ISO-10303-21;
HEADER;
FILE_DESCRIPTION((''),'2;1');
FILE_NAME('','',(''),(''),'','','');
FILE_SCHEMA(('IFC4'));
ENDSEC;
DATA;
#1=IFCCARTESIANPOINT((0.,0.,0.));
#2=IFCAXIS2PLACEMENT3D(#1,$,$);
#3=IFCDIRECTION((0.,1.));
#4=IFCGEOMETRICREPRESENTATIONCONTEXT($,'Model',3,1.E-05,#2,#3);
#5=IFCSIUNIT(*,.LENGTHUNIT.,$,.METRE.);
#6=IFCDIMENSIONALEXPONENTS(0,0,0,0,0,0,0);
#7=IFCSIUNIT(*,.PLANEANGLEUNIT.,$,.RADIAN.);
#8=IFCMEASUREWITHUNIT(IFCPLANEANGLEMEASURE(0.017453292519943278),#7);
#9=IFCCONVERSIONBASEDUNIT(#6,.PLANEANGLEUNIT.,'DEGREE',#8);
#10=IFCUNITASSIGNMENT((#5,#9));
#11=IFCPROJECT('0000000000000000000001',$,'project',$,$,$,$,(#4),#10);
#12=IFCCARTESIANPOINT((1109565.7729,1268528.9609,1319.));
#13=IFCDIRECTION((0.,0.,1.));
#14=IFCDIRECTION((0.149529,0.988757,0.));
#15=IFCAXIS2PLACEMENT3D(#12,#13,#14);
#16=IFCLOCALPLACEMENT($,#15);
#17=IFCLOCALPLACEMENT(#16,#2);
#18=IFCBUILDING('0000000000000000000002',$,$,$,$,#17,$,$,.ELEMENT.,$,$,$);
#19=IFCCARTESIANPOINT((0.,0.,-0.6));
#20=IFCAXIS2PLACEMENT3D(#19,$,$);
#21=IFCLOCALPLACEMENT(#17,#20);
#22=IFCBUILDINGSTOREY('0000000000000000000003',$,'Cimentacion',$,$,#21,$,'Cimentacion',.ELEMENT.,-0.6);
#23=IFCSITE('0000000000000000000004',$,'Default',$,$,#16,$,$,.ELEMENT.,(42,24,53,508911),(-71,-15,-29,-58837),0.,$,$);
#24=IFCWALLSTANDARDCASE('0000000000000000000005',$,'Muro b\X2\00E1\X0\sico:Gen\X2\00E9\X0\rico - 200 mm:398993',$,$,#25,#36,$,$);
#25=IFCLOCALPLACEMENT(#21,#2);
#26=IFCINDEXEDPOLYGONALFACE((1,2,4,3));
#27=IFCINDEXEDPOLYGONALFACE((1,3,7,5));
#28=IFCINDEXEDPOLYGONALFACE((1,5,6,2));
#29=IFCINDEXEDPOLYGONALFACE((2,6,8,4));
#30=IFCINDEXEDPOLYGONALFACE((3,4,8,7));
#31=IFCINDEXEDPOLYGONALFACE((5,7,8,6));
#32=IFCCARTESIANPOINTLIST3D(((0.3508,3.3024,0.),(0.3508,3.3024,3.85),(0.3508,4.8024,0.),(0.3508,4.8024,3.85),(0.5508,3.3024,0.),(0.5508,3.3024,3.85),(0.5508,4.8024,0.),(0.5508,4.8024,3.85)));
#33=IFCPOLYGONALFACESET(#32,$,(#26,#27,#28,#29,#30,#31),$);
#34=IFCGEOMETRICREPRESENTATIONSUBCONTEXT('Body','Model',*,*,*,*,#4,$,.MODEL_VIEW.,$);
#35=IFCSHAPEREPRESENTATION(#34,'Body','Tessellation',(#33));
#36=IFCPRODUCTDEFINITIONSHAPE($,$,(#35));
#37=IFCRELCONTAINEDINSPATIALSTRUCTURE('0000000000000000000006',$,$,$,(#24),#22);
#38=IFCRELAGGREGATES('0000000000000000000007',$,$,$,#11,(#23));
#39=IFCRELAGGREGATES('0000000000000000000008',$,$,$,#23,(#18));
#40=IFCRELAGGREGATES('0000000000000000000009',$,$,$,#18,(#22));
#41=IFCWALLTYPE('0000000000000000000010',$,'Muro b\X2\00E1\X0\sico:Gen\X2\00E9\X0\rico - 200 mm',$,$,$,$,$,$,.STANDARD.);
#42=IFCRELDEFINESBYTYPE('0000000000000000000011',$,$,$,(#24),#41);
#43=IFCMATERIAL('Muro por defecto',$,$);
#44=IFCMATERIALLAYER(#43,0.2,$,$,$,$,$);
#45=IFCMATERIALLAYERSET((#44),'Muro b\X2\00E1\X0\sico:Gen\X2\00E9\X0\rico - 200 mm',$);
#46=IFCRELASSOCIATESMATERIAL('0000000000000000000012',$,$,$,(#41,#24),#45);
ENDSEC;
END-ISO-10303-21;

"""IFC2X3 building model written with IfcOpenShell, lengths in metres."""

from ifc_helpers import new_model, entity, si_unit, converted_unit, direction, frame, frame_2d, origin, place, context, subcontext, project, spatial, rectangle, extrude, material, layer, layer_set, layer_usage, type_object, element, save


model = new_model("IFC2X3")

# Units and contexts
model_context = context("Model", 3, precision=1e-05, world=origin(), true_north=direction((0.0, 1.0)))
body_context = subcontext(model_context, "Body", "Model", "MODEL_VIEW")
ifc_project = project(units=[si_unit("LENGTHUNIT", "METRE"), converted_unit("PLANEANGLEUNIT", "DEGREE", entity("IfcPlaneAngleMeasure", 0.017453292519943278), si_unit("PLANEANGLEUNIT", "RADIAN"), dimensions=[0, 0, 0, 0, 0, 0, 0])], contexts=[model_context])

# Site, building, storey
site_placement = place(None, frame((1109565.7729, 1268528.9609, 1319.0), z_axis=(0.0, 0.0, 1.0), x_axis=(0.149529, 0.988757, 0.0)))
site = spatial("IfcSite", under=ifc_project, at=site_placement, Name="Default", CompositionType="ELEMENT", RefLatitude=(42, 24, 53, 508911), RefLongitude=(-71, -15, -29, -58837), RefElevation=0.0)
building_placement = place(site_placement, origin())
building = spatial("IfcBuilding", under=site, at=building_placement, CompositionType="ELEMENT")
storey_placement = place(building_placement, frame((0.0, 0.0, -0.6)))
storey = spatial("IfcBuildingStorey", under=building, at=storey_placement, Name="Cimentacion", LongName="Cimentacion", CompositionType="ELEMENT", Elevation=-0.6)

# Wall
ifc_material_1 = material(Name="Muro por defecto")
ifc_layer = layer(ifc_material_1, 0.2)
ifc_layer_set = layer_set([ifc_layer], Name="Muro básico:Genérico - 200 mm")
ifc_layer_usage = layer_usage(ifc_layer_set, "AXIS2", "NEGATIVE", 0.1)
wall_type = type_object("IfcWallType", Name="Muro básico:Genérico - 200 mm", PredefinedType="STANDARD", material=ifc_layer_set)
wall_placement = place(storey_placement, frame((0.4508, 4.8024, 0.0), z_axis=(0.0, 0.0, 1.0), x_axis=(0.0, -1.0, 0.0)))
element("IfcWallStandardCase", 1, at=wall_placement, inside=storey, type_object=wall_type, material=ifc_layer_usage, Name="Muro básico:Genérico - 200 mm:398993", context=body_context, shape_type="SweptSolid", body=[
    extrude(rectangle(XDim=1.5, YDim=0.2, at=frame_2d((0.75, 0.0), x_axis=(-1.0, 0.0))), origin(), (0.0, 0.0, 1.0), 3.85),
])

save(model, "model.ifc")
